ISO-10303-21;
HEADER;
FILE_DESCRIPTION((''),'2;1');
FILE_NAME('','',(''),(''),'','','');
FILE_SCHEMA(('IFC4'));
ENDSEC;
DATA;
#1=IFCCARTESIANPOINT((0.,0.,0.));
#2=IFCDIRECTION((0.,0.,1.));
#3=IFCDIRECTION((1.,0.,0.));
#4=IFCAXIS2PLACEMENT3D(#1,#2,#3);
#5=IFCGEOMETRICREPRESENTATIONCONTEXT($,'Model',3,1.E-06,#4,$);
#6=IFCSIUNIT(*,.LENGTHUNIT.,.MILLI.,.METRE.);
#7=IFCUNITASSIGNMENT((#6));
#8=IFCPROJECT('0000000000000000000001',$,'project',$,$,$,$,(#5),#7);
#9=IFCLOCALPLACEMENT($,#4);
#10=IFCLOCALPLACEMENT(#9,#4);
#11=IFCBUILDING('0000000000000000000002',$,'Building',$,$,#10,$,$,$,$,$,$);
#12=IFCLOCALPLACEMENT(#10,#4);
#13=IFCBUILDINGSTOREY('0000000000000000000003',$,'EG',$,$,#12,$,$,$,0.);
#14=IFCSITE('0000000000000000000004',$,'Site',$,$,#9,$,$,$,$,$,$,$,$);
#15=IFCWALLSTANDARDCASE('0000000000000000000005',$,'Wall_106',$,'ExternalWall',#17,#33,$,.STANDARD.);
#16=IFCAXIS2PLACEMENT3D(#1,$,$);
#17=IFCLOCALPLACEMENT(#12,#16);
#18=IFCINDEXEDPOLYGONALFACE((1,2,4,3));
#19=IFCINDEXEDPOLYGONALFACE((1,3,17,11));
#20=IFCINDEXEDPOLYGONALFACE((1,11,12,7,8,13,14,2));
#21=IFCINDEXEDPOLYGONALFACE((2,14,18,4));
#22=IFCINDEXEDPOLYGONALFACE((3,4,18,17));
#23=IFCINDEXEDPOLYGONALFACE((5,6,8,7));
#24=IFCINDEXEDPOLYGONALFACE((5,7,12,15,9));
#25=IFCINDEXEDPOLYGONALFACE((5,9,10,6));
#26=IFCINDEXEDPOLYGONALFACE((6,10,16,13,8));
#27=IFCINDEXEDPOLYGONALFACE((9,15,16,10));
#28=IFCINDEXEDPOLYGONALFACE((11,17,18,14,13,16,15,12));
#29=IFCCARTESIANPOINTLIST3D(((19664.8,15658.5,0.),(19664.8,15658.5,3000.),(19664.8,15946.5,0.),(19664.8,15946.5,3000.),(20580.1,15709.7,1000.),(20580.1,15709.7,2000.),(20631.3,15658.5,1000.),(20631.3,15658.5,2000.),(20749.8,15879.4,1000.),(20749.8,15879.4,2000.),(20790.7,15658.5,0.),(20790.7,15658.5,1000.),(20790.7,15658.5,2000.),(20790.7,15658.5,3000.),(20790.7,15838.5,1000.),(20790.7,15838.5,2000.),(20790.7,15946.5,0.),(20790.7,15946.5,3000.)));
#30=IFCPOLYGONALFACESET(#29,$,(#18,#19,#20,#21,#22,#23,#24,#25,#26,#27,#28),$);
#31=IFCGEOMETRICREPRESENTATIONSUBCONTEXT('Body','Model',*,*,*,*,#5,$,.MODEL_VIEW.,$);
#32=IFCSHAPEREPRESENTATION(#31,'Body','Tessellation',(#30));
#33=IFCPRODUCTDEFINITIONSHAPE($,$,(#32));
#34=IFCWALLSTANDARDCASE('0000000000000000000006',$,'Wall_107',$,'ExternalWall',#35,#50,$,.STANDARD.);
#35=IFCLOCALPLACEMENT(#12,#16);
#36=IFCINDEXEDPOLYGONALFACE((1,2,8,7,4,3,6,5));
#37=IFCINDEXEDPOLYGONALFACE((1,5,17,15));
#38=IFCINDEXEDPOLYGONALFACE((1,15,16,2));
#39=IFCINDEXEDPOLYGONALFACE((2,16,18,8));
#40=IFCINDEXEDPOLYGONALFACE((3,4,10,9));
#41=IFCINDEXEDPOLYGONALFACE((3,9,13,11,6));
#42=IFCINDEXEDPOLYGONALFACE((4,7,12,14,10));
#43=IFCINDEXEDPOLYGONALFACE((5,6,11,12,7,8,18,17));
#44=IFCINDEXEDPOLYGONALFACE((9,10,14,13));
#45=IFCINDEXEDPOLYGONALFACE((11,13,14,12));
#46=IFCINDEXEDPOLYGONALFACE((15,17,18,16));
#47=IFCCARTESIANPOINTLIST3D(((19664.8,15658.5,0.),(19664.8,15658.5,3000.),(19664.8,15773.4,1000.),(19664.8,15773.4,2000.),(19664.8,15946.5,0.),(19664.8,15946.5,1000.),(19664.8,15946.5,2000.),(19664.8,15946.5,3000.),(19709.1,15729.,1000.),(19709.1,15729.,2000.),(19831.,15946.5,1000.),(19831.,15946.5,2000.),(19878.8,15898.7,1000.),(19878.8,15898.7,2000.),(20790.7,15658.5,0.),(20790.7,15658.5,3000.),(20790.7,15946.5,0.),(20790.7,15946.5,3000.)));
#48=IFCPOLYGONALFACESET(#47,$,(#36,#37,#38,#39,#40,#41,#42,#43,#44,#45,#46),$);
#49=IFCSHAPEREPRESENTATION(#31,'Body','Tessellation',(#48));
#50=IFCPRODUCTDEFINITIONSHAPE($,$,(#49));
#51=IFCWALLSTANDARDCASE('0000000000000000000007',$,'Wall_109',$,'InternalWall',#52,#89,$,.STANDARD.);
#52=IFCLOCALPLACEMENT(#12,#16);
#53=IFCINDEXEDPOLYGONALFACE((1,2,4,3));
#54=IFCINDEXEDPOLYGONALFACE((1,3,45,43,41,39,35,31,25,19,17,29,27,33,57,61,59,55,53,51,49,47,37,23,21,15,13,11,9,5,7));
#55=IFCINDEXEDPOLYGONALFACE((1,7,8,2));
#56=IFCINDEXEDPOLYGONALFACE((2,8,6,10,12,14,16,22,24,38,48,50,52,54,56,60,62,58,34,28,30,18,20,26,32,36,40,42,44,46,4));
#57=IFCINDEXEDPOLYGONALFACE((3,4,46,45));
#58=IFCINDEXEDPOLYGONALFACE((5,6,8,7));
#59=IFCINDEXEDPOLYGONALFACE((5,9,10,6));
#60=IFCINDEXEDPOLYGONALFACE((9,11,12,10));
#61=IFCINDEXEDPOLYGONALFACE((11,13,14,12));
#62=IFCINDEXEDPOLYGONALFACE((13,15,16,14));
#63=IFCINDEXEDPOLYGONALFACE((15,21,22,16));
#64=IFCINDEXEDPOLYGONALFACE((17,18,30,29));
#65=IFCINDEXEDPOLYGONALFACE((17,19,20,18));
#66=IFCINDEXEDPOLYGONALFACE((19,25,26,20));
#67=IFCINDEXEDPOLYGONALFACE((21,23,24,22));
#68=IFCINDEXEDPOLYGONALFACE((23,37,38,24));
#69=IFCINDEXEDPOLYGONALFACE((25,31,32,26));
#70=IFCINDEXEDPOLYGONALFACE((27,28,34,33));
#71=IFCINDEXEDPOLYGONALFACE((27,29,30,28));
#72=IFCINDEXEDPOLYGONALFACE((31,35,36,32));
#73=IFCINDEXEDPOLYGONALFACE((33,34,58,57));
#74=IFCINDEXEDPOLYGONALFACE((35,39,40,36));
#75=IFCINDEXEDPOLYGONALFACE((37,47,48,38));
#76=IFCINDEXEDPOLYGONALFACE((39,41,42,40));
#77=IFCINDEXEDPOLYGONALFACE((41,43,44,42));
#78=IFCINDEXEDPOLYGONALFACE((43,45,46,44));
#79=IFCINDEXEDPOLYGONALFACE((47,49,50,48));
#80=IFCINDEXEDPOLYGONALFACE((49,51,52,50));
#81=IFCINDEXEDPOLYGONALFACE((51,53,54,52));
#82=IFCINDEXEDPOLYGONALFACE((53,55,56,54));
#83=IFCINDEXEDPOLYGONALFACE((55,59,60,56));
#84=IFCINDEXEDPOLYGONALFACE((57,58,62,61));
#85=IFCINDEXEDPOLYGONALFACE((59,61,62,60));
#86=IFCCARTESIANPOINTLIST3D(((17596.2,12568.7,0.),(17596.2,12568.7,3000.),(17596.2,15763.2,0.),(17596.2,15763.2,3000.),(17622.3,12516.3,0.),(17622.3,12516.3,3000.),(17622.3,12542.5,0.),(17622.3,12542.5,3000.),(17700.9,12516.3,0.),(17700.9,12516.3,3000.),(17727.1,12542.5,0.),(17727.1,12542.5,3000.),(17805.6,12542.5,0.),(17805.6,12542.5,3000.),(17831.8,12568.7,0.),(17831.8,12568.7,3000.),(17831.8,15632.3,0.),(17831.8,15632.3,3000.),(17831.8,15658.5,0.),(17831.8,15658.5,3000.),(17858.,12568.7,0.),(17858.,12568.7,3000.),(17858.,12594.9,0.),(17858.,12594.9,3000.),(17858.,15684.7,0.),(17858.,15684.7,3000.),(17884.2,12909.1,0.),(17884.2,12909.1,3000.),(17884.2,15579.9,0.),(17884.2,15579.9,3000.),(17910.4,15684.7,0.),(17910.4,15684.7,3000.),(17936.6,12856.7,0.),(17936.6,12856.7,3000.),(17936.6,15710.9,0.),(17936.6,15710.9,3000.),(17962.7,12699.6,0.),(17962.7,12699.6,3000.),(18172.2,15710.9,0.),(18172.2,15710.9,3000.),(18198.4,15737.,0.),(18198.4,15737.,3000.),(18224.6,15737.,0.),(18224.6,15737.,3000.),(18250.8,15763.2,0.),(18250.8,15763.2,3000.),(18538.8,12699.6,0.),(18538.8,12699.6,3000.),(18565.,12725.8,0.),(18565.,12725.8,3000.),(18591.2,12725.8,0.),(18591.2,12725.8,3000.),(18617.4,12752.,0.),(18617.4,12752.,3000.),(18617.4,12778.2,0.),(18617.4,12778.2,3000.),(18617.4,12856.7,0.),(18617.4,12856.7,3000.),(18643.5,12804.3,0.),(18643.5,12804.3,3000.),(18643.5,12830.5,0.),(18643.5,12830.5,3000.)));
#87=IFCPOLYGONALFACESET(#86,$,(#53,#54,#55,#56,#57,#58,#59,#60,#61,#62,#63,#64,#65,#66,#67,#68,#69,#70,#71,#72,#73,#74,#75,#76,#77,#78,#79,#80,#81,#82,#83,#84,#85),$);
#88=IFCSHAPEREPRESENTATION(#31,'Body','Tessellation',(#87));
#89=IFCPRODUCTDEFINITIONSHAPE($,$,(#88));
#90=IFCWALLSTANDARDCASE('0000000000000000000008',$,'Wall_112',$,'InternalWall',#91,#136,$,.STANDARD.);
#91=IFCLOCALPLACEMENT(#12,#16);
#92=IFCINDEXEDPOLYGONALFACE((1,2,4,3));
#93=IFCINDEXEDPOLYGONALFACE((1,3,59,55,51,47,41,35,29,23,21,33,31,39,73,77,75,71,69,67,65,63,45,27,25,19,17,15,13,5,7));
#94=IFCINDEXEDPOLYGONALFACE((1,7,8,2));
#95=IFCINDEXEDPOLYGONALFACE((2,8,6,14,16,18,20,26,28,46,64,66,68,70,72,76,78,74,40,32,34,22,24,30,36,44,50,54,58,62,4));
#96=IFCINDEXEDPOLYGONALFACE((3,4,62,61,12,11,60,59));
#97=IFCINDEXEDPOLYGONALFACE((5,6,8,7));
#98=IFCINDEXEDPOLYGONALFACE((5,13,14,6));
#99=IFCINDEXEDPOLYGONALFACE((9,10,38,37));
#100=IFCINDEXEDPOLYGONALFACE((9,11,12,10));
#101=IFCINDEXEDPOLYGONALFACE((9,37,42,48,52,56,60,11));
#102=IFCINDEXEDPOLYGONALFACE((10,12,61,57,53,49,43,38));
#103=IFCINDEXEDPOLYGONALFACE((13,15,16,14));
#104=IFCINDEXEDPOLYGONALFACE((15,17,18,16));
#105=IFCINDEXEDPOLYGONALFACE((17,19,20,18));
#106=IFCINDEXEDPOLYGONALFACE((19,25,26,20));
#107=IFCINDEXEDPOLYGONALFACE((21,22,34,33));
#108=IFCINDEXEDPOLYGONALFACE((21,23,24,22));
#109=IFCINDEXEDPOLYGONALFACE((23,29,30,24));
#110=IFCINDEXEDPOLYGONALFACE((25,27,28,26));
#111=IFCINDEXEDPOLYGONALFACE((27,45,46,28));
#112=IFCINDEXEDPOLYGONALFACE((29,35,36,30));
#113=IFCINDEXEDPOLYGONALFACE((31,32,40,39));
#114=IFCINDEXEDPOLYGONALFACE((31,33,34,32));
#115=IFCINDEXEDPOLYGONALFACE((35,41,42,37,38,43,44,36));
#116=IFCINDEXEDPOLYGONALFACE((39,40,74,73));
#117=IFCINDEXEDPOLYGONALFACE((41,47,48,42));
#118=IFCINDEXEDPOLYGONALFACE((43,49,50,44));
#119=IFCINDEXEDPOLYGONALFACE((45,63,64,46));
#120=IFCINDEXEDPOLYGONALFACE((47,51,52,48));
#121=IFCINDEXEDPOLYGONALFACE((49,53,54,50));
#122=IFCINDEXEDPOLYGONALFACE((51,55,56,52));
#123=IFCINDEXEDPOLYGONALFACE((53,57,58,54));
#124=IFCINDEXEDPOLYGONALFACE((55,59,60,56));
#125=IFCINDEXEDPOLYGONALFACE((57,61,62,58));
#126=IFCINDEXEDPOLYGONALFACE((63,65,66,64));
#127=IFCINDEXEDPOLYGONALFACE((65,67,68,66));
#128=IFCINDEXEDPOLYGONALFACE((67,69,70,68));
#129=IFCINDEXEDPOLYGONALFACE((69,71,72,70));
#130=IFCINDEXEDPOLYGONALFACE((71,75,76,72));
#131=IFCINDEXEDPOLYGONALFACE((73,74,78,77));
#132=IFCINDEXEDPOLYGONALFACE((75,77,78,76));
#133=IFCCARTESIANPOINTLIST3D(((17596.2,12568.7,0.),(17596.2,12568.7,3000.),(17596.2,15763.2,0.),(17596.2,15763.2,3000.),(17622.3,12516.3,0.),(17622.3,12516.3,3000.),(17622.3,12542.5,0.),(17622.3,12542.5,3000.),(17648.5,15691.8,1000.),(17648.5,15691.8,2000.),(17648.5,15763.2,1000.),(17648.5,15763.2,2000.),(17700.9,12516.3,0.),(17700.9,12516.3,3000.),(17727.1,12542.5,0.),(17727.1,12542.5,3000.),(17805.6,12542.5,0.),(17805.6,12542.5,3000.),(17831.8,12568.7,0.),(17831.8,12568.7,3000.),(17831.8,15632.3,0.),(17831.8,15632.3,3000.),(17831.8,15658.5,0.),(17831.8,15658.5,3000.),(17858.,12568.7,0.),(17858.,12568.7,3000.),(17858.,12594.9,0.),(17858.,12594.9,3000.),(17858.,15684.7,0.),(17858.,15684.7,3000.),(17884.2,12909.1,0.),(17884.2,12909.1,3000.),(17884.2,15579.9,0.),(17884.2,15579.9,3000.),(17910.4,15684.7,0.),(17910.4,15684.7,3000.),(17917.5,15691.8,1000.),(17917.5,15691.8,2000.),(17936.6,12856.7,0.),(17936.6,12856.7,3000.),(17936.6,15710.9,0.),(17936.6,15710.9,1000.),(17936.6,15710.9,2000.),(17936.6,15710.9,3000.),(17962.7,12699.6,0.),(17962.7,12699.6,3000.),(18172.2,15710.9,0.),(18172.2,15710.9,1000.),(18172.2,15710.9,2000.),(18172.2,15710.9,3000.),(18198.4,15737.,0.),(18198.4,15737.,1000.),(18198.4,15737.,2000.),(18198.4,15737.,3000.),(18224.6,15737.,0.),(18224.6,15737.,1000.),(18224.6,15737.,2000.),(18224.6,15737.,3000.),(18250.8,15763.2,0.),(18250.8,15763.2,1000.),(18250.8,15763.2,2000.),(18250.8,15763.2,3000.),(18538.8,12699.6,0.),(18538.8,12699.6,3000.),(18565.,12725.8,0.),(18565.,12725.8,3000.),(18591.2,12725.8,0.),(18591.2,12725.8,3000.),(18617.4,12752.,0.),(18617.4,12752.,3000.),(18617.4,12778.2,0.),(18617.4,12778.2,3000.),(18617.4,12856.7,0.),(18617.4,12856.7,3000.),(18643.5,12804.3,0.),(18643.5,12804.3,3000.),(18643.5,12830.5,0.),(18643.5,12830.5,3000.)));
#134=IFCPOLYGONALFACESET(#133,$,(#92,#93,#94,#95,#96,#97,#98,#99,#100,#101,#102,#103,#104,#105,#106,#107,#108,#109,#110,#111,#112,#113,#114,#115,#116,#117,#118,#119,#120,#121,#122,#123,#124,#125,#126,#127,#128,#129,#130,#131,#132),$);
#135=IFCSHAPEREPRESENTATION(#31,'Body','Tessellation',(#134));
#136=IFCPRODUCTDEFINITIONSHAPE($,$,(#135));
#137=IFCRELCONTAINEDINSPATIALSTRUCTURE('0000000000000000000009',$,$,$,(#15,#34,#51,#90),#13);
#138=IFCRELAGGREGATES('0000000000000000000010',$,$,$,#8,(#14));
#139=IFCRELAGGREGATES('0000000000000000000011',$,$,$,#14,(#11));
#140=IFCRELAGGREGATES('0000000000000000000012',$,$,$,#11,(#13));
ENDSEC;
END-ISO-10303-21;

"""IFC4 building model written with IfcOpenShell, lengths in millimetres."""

from ifc_helpers import new_model, si_unit, frame, origin_with_axes, place, context, subcontext, project, spatial, polyline, rectangle, outline, extrude, element, save


model = new_model("IFC4")

# Units and contexts
model_context = context("Model", 3, precision=1e-06, world=origin_with_axes())
body_context = subcontext(model_context, "Body", "Model", "MODEL_VIEW")
ifc_project = project(units=[si_unit("LENGTHUNIT", "METRE", prefix="MILLI")], contexts=[model_context])

# Site, building, storey
site_placement = place(None, origin_with_axes())
site = spatial("IfcSite", under=ifc_project, at=site_placement, Name="Site")
building_placement = place(site_placement, origin_with_axes())
building = spatial("IfcBuilding", under=site, at=building_placement, Name="Building")
storey_placement = place(building_placement, origin_with_axes())
storey = spatial("IfcBuildingStorey", under=building, at=storey_placement, Name="EG", Elevation=0.0)

# Walls, openings
wall_1_placement = place(storey_placement, origin_with_axes())
wall_1 = element("IfcWallStandardCase", 1, at=wall_1_placement, inside=storey, Name="Wall_106", ObjectType="ExternalWall", PredefinedType="STANDARD", context=body_context, shape_type="SweptSolid", body=[
    extrude(outline(polyline([(19664.8, 15658.5, 0.0), (19664.8, 15946.5, 0.0), (20790.7, 15946.5, 0.0), (20790.7, 15658.5, 0.0), (19664.8, 15658.5, 0.0)])), origin_with_axes(), (0.0, 0.0, 1.0), 3000.0),
])
opening_1_placement = place(wall_1_placement, origin_with_axes())
element("IfcOpeningElement", 2, at=opening_1_placement, inside=storey, cuts=wall_1, context=body_context, shape_type="SweptSolid", body=[
    extrude(rectangle(XDim=2073.7, YDim=240.0), frame((21398.1, 15061.4, 1000.0), z_axis=(0.0, 0.0, 1.0), x_axis=(0.707107, -0.707107, 0.0)), (0.0, 0.0, 1.0), 1000.0),
])
wall_2_placement = place(storey_placement, origin_with_axes())
wall_2 = element("IfcWallStandardCase", 3, at=wall_2_placement, inside=storey, Name="Wall_107", ObjectType="ExternalWall", PredefinedType="STANDARD", context=body_context, shape_type="SweptSolid", body=[
    extrude(outline(polyline([(19664.8, 15658.5, 0.0), (19664.8, 15946.5, 0.0), (20790.7, 15946.5, 0.0), (20790.7, 15658.5, 0.0), (19664.8, 15658.5, 0.0)])), origin_with_axes(), (0.0, 0.0, 1.0), 3000.0),
])
opening_2_placement = place(wall_2_placement, origin_with_axes())
element("IfcOpeningElement", 4, at=opening_2_placement, inside=storey, cuts=wall_2, context=body_context, shape_type="SweptSolid", body=[
    extrude(rectangle(XDim=1110.9, YDim=240.0), frame((19401.2, 16206.7, 1000.0), z_axis=(0.0, 0.0, 1.0), x_axis=(-0.707107, 0.707107, 0.0)), (0.0, 0.0, 1.0), 1000.0),
])

# Wall
for number, where, z_axis, x_axis, name in (
    (5, (0.0, 0.0, 0.0), (0.0, 0.0, 1.0), (1.0, 0.0, 0.0), "Wall_109"),
):
    element("IfcWallStandardCase", number, at=place(storey_placement, frame(where, z_axis=z_axis, x_axis=x_axis)), inside=storey, Name=name, ObjectType="InternalWall", PredefinedType="STANDARD", context=body_context, shape_type="SweptSolid", body=[
        extrude(outline(polyline([(17622.3, 12516.3, 0.0), (17622.3, 12542.5, 0.0), (17596.2, 12568.7, 0.0), (17596.2, 15763.2, 0.0), (18250.8, 15763.2, 0.0), (18224.6, 15737.0, 0.0), (18198.4, 15737.0, 0.0), (18172.2, 15710.9, 0.0), (17936.6, 15710.9, 0.0), (17910.4, 15684.7, 0.0), (17858.0, 15684.7, 0.0), (17831.8, 15658.5, 0.0), (17831.8, 15632.3, 0.0), (17884.2, 15579.9, 0.0), (17884.2, 12909.1, 0.0), (17936.6, 12856.7, 0.0), (18617.4, 12856.7, 0.0), (18643.5, 12830.5, 0.0), (18643.5, 12804.3, 0.0), (18617.4, 12778.2, 0.0), (18617.4, 12752.0, 0.0), (18591.2, 12725.8, 0.0), (18565.0, 12725.8, 0.0), (18538.8, 12699.6, 0.0), (17962.7, 12699.6, 0.0), (17858.0, 12594.9, 0.0), (17858.0, 12568.7, 0.0), (17831.8, 12568.7, 0.0), (17805.6, 12542.5, 0.0), (17727.1, 12542.5, 0.0), (17700.9, 12516.3, 0.0), (17622.3, 12516.3, 0.0)])), origin_with_axes(), (0.0, 0.0, 1.0), 3000.0),
    ])

# Wall, opening
wall_3_placement = place(storey_placement, origin_with_axes())
wall_3 = element("IfcWallStandardCase", 6, at=wall_3_placement, inside=storey, Name="Wall_112", ObjectType="InternalWall", PredefinedType="STANDARD", context=body_context, shape_type="SweptSolid", body=[
    extrude(outline(polyline([(17622.3, 12516.3, 0.0), (17622.3, 12542.5, 0.0), (17596.2, 12568.7, 0.0), (17596.2, 15763.2, 0.0), (18250.8, 15763.2, 0.0), (18224.6, 15737.0, 0.0), (18198.4, 15737.0, 0.0), (18172.2, 15710.9, 0.0), (17936.6, 15710.9, 0.0), (17910.4, 15684.7, 0.0), (17858.0, 15684.7, 0.0), (17831.8, 15658.5, 0.0), (17831.8, 15632.3, 0.0), (17884.2, 15579.9, 0.0), (17884.2, 12909.1, 0.0), (17936.6, 12856.7, 0.0), (18617.4, 12856.7, 0.0), (18643.5, 12830.5, 0.0), (18643.5, 12804.3, 0.0), (18617.4, 12778.2, 0.0), (18617.4, 12752.0, 0.0), (18591.2, 12725.8, 0.0), (18565.0, 12725.8, 0.0), (18538.8, 12699.6, 0.0), (17962.7, 12699.6, 0.0), (17858.0, 12594.9, 0.0), (17858.0, 12568.7, 0.0), (17831.8, 12568.7, 0.0), (17805.6, 12542.5, 0.0), (17727.1, 12542.5, 0.0), (17700.9, 12516.3, 0.0), (17622.3, 12516.3, 0.0)])), origin_with_axes(), (0.0, 0.0, 1.0), 3000.0),
])
opening_3_placement = place(wall_3_placement, origin_with_axes())
element("IfcOpeningElement", 7, at=opening_3_placement, inside=storey, cuts=wall_3, context=body_context, shape_type="SweptSolid", body=[
    extrude(rectangle(XDim=1963.9, YDim=115.0), frame((18630.5, 15749.3, 1000.0), z_axis=(0.0, 0.0, 1.0), x_axis=(1.0, 0.0, 0.0)), (0.0, 0.0, 1.0), 1000.0),
])

save(model, "model.ifc")
